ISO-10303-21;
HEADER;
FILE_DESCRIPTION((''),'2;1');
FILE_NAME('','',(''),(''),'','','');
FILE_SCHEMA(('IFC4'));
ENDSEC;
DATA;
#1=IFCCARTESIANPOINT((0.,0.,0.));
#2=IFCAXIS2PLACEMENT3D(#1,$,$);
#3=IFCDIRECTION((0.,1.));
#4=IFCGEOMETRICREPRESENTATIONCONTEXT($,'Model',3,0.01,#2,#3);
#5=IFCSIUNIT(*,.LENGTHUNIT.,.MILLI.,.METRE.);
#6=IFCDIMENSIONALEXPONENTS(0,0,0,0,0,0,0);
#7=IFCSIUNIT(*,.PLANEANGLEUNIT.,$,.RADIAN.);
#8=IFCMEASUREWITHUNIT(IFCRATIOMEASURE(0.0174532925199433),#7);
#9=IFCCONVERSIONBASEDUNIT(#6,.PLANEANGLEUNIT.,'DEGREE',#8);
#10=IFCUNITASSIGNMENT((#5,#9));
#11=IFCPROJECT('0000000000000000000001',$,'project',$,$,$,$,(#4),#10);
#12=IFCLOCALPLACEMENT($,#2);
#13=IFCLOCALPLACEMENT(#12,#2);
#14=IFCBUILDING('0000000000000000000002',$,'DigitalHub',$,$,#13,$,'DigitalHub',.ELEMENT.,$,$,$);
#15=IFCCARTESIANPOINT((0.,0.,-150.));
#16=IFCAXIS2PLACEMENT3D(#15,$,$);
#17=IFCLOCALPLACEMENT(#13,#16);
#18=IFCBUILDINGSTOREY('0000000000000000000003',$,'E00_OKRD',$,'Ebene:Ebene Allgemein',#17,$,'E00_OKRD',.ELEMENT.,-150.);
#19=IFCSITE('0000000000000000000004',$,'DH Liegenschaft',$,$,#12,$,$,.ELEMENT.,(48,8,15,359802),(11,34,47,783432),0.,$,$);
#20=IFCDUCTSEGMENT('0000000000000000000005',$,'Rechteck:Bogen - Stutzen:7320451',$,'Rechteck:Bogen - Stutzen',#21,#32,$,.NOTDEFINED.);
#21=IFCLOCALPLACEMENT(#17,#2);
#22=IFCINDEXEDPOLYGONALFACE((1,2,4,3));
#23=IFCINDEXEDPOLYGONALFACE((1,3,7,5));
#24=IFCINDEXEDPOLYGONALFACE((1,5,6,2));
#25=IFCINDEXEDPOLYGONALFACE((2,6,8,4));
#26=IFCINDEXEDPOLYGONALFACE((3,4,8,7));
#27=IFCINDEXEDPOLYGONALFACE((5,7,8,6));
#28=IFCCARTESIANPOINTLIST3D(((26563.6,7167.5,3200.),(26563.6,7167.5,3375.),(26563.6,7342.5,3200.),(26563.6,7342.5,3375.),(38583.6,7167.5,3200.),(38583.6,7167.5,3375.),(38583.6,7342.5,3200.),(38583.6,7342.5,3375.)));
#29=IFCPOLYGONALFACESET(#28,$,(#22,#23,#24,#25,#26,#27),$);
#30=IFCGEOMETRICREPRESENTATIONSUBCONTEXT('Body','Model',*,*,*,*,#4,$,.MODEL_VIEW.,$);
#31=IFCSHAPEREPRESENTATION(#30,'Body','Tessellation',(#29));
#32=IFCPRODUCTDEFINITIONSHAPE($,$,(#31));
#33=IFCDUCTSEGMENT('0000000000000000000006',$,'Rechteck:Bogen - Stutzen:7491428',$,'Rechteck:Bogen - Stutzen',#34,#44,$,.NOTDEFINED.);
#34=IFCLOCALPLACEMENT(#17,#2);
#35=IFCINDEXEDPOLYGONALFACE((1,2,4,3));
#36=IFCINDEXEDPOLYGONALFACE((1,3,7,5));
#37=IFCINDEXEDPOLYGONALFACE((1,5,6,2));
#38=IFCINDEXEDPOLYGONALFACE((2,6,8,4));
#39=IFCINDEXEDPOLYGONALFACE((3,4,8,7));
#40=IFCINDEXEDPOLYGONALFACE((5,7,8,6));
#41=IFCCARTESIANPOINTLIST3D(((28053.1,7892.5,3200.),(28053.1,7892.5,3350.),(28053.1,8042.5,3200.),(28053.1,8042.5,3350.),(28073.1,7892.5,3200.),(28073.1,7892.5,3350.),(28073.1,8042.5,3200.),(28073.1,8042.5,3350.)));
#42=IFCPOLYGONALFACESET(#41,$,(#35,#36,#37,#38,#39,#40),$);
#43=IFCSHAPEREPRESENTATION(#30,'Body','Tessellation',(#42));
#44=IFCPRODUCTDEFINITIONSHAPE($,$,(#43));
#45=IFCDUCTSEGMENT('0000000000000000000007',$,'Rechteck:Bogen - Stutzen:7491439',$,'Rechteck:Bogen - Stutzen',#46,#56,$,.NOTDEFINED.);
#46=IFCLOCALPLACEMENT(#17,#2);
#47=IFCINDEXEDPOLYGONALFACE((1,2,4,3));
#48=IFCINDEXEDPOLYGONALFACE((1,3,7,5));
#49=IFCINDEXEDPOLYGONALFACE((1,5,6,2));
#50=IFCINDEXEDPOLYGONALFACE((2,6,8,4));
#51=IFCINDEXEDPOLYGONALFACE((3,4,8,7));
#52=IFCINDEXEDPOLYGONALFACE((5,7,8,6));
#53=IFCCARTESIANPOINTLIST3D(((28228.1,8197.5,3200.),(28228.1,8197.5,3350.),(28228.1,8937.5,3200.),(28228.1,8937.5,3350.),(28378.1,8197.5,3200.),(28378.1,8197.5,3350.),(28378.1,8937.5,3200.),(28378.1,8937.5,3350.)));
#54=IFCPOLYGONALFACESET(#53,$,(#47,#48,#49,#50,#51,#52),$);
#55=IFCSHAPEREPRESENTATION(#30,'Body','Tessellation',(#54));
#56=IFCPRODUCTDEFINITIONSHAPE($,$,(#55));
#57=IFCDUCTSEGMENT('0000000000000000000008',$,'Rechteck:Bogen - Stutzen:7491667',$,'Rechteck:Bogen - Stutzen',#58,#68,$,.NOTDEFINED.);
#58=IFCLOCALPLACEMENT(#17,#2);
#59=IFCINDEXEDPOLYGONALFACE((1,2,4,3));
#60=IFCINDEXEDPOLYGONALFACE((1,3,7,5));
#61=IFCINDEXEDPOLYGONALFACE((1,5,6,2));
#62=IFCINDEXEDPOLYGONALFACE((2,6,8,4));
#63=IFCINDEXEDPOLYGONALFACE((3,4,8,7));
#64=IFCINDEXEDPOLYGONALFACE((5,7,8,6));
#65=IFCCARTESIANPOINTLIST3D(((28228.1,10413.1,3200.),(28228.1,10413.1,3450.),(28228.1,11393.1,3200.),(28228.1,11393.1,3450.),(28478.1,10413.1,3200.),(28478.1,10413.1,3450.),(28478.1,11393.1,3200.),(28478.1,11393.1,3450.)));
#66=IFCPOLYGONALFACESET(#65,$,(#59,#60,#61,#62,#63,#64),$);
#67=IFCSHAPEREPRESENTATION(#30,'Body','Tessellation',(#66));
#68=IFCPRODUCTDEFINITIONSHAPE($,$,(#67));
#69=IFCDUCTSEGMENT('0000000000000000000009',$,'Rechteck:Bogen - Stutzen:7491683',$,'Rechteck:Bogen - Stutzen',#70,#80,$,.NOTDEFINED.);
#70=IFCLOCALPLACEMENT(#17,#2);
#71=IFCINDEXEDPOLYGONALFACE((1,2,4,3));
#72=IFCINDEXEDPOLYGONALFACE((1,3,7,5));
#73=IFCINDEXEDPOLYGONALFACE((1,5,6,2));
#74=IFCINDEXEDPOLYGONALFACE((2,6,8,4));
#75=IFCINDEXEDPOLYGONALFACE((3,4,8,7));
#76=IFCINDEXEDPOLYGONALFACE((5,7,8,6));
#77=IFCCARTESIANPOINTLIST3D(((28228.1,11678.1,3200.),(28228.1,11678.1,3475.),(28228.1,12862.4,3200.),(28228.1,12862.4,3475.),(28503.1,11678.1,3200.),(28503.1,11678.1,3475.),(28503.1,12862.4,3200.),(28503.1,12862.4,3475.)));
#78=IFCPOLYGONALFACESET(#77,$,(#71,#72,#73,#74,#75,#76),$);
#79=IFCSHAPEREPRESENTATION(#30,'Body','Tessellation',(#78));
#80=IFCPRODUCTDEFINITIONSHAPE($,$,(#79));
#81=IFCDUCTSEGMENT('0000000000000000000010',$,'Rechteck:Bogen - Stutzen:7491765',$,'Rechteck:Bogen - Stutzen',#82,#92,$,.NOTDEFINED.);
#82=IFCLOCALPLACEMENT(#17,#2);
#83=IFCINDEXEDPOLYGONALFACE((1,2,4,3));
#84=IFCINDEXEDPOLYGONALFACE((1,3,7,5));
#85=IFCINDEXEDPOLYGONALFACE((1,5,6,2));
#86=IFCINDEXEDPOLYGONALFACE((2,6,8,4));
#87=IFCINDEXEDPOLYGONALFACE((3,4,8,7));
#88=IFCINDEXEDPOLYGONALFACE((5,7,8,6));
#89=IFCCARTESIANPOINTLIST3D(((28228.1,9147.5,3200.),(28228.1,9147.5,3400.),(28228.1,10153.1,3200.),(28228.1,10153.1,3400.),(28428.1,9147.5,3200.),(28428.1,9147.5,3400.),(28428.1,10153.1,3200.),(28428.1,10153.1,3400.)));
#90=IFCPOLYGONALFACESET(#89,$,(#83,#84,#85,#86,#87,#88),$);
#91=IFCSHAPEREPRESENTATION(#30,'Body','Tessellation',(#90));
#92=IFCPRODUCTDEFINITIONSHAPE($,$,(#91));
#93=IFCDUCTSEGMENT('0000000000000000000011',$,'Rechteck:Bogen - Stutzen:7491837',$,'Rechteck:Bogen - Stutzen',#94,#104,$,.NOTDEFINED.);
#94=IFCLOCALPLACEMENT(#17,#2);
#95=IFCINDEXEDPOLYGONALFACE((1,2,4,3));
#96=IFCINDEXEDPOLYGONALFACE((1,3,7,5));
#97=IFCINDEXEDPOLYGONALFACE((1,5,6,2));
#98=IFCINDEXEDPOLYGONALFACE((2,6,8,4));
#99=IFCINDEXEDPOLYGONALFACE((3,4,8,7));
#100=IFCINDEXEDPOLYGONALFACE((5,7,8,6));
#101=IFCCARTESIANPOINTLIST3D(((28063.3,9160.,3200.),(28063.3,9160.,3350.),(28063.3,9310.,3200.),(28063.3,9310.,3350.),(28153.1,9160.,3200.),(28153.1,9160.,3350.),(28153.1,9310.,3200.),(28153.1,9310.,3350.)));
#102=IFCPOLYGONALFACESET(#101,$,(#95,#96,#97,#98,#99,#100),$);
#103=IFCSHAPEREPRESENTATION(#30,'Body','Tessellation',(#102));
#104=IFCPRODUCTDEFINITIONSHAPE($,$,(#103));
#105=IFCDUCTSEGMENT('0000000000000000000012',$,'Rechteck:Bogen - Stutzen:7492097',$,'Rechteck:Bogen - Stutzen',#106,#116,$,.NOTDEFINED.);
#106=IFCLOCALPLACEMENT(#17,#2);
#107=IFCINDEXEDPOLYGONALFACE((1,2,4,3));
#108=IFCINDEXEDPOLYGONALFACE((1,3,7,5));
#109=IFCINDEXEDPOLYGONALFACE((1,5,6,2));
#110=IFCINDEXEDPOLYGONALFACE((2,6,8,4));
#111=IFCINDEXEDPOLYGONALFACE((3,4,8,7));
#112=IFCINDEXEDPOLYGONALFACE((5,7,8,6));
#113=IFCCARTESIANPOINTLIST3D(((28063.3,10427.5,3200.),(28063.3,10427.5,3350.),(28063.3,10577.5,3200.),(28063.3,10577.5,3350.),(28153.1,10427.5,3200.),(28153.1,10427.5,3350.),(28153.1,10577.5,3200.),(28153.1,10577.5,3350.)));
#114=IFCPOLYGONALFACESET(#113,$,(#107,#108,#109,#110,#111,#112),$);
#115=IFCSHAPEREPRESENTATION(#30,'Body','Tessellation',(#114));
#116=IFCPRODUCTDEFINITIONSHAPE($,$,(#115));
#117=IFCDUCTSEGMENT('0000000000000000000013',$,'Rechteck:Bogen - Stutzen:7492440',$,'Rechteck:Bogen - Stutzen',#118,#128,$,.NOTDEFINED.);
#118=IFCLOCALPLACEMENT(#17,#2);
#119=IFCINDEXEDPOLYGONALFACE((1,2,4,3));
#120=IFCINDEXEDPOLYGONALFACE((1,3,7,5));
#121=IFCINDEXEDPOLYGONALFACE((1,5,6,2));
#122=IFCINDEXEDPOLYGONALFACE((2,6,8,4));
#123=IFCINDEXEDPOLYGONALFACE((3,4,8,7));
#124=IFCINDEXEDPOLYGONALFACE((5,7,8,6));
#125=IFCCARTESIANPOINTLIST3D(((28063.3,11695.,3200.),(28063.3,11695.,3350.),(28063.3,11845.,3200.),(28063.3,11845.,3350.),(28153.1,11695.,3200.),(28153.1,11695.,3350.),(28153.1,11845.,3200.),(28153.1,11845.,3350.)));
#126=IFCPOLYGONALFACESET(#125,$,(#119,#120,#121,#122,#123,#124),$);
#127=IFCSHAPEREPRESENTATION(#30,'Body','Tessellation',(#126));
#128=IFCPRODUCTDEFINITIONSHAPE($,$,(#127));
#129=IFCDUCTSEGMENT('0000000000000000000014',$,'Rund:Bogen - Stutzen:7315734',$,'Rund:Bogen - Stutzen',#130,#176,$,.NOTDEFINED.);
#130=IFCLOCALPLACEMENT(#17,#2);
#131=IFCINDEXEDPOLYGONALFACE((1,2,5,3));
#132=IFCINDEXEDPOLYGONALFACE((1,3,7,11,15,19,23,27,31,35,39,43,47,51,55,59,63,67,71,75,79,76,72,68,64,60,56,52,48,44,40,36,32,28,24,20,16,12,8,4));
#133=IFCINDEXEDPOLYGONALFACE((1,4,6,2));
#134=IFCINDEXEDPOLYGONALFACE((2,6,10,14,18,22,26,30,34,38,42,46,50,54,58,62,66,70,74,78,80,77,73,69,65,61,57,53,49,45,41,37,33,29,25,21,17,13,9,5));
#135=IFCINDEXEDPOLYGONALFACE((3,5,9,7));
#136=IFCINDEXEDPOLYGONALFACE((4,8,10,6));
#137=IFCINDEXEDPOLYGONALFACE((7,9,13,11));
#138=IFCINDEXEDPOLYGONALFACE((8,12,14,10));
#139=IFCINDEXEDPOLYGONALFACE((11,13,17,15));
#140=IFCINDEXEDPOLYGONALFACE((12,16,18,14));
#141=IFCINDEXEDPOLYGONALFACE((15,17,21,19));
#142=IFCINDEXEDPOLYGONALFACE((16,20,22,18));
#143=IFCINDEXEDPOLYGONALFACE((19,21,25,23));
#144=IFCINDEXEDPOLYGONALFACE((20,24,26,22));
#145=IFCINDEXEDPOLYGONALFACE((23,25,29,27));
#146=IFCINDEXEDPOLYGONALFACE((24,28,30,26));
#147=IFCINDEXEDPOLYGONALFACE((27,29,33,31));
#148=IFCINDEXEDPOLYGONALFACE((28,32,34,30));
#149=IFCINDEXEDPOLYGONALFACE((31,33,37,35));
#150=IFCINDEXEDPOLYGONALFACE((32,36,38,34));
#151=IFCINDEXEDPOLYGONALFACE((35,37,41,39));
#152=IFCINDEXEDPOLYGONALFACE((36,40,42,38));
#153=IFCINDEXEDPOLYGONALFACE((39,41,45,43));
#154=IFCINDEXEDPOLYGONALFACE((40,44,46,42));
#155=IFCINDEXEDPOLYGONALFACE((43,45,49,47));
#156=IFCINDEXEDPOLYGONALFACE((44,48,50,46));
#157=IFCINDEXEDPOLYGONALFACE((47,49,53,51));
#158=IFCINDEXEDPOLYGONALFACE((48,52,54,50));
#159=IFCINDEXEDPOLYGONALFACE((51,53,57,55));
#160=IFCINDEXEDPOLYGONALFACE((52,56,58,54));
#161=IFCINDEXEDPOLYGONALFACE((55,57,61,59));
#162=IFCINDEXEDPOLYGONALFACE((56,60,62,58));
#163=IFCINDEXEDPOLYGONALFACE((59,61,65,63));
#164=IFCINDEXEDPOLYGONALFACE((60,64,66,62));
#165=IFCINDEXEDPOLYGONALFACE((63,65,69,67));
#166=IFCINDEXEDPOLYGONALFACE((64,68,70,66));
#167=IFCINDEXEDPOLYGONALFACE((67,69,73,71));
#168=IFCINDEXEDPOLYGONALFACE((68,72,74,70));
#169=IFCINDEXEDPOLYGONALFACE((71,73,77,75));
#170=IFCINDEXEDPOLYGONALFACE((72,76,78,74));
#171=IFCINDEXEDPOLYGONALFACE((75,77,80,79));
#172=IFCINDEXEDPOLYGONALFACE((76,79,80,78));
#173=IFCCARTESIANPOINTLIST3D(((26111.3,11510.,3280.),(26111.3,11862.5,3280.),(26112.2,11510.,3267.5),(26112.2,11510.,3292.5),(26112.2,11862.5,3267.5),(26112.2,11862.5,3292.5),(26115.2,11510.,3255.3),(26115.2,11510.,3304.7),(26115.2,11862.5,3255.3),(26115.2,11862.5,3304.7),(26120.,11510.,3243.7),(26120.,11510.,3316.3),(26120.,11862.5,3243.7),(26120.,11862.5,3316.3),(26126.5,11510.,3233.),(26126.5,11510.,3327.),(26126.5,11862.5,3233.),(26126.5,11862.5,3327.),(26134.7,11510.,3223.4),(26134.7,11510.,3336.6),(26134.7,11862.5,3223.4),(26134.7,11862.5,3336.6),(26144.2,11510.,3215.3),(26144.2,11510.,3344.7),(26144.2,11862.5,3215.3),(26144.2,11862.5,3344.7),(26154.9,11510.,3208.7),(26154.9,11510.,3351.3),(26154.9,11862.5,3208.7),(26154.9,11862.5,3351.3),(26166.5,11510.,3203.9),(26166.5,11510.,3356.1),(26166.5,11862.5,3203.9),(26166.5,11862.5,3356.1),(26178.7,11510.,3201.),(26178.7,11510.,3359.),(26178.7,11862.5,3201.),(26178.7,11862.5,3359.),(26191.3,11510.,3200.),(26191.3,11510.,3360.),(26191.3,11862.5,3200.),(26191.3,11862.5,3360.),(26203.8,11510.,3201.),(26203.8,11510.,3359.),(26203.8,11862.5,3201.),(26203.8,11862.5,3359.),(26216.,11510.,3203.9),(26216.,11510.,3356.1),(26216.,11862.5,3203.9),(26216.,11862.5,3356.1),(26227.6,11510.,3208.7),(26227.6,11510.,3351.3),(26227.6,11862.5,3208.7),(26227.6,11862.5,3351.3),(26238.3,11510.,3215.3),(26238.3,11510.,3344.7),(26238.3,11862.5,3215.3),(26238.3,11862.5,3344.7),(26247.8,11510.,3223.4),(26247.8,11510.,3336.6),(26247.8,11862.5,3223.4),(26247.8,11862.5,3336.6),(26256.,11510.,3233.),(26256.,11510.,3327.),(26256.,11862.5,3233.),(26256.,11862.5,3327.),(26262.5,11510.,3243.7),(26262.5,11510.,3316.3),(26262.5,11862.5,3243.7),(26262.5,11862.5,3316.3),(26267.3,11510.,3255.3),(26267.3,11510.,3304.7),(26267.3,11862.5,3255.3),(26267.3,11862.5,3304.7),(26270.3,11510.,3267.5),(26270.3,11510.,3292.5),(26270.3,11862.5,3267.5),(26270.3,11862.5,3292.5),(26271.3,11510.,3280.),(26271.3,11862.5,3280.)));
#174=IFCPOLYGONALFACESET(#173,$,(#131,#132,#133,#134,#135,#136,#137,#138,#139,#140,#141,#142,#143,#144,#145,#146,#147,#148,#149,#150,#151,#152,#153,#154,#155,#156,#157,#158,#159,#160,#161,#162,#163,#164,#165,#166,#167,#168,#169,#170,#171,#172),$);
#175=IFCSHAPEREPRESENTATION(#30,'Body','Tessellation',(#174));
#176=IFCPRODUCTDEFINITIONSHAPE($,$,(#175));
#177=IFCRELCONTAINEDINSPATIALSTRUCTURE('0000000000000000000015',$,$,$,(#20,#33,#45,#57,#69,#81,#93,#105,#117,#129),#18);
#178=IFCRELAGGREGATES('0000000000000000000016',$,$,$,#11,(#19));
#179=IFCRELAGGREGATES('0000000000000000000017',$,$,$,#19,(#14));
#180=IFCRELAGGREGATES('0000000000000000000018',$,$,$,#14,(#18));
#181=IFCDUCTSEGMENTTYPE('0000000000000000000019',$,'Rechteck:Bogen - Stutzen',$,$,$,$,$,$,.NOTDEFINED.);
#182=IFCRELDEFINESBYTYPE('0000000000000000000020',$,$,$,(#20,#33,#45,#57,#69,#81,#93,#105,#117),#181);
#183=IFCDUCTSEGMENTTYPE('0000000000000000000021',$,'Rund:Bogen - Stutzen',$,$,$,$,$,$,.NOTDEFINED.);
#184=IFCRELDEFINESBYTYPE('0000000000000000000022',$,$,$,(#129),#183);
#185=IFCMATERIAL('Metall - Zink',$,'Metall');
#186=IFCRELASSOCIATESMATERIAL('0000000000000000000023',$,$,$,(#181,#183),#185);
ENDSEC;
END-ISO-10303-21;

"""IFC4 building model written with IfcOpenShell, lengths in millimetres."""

from ifc_helpers import new_model, entity, si_unit, converted_unit, direction, frame, origin, place, context, subcontext, project, spatial, indexed_curve, outline, extrude, material, type_object, element, save


model = new_model("IFC4")

# Units and contexts
model_context = context("Model", 3, precision=0.01, world=origin(), true_north=direction((0.0, 1.0)))
body_context = subcontext(model_context, "Body", "Model", "MODEL_VIEW")
ifc_project = project(units=[si_unit("LENGTHUNIT", "METRE", prefix="MILLI"), converted_unit("PLANEANGLEUNIT", "DEGREE", entity("IfcRatioMeasure", 0.0174532925199433), si_unit("PLANEANGLEUNIT", "RADIAN"), dimensions=[0, 0, 0, 0, 0, 0, 0])], contexts=[model_context])

# Site, building, storey
site_placement = place(None, origin())
site = spatial("IfcSite", under=ifc_project, at=site_placement, Name="DH Liegenschaft", CompositionType="ELEMENT", RefLatitude=(48, 8, 15, 359802), RefLongitude=(11, 34, 47, 783432), RefElevation=0.0)
building_placement = place(site_placement, origin())
building = spatial("IfcBuilding", under=site, at=building_placement, Name="DigitalHub", LongName="DigitalHub", CompositionType="ELEMENT")
storey_placement = place(building_placement, frame((0.0, 0.0, -150.0)))
storey = spatial("IfcBuildingStorey", under=building, at=storey_placement, Name="E00_OKRD", ObjectType="Ebene:Ebene Allgemein", LongName="E00_OKRD", CompositionType="ELEMENT", Elevation=-150.0)

# Duct segments
ifc_material_1 = material(Name="Metall - Zink", Category="Metall")
duct_segment_type_1 = type_object("IfcDuctSegmentType", Name="Rechteck:Bogen - Stutzen", PredefinedType="NOTDEFINED", material=ifc_material_1)
duct_segment_1_placement = place(storey_placement, frame((26563.6, 7167.5, 3200.0)))
element("IfcDuctSegment", 1, at=duct_segment_1_placement, inside=storey, type_object=duct_segment_type_1, Name="Rechteck:Bogen - Stutzen:7320451", ObjectType="Rechteck:Bogen - Stutzen", PredefinedType="NOTDEFINED", context=body_context, shape_type="SweptSolid", body=[
    extrude(outline(indexed_curve([(-6010.0, -87.5), (6010.0, -87.5), (6010.0, 87.5), (-6010.0, 87.5), (-6010.0, -87.5)], self_intersect=False)), frame((6010.0, 87.5, 0.0), z_axis=(0.0, 0.0, 1.0), x_axis=(-1.0, 0.0, 0.0)), (0.0, 0.0, 1.0), 175.0),
])
duct_segment_2_placement = place(storey_placement, frame((28053.1, 7892.5, 3200.0)))
element("IfcDuctSegment", 2, at=duct_segment_2_placement, inside=storey, type_object=duct_segment_type_1, Name="Rechteck:Bogen - Stutzen:7491428", ObjectType="Rechteck:Bogen - Stutzen", PredefinedType="NOTDEFINED", context=body_context, shape_type="SweptSolid", body=[
    extrude(outline(indexed_curve([(-10.0, -75.0), (10.0, -75.0), (10.0, 75.0), (-10.0, 75.0), (-10.0, -75.0)], self_intersect=False)), frame((10.0, 75.0, 0.0)), (0.0, 0.0, 1.0), 150.0),
])
duct_segment_3_placement = place(storey_placement, frame((28228.1, 8197.5, 3200.0)))
element("IfcDuctSegment", 3, at=duct_segment_3_placement, inside=storey, type_object=duct_segment_type_1, Name="Rechteck:Bogen - Stutzen:7491439", ObjectType="Rechteck:Bogen - Stutzen", PredefinedType="NOTDEFINED", context=body_context, shape_type="SweptSolid", body=[
    extrude(outline(indexed_curve([(-370.0, -75.0), (370.0, -75.0), (370.0, 75.0), (-370.0, 75.0), (-370.0, -75.0)], self_intersect=False)), frame((75.0, 370.0, 0.0), z_axis=(0.0, 0.0, 1.0), x_axis=(0.0, 1.0, 0.0)), (0.0, 0.0, 1.0), 150.0),
])
duct_segment_4_placement = place(storey_placement, frame((28228.1, 10413.1, 3200.0)))
element("IfcDuctSegment", 4, at=duct_segment_4_placement, inside=storey, type_object=duct_segment_type_1, Name="Rechteck:Bogen - Stutzen:7491667", ObjectType="Rechteck:Bogen - Stutzen", PredefinedType="NOTDEFINED", context=body_context, shape_type="SweptSolid", body=[
    extrude(outline(indexed_curve([(-490.0, -125.0), (490.0, -125.0), (490.0, 125.0), (-490.0, 125.0), (-490.0, -125.0)], self_intersect=False)), frame((125.0, 490.0, 0.0), z_axis=(0.0, 0.0, 1.0), x_axis=(0.0, 1.0, 0.0)), (0.0, 0.0, 1.0), 250.0),
])
duct_segment_5_placement = place(storey_placement, frame((28228.1, 11678.1, 3200.0)))
element("IfcDuctSegment", 5, at=duct_segment_5_placement, inside=storey, type_object=duct_segment_type_1, Name="Rechteck:Bogen - Stutzen:7491683", ObjectType="Rechteck:Bogen - Stutzen", PredefinedType="NOTDEFINED", context=body_context, shape_type="SweptSolid", body=[
    extrude(outline(indexed_curve([(-592.2, -137.5), (592.2, -137.5), (592.2, 137.5), (-592.2, 137.5), (-592.2, -137.5)], self_intersect=False)), frame((137.5, 592.2, 0.0), z_axis=(0.0, 0.0, 1.0), x_axis=(0.0, 1.0, 0.0)), (0.0, 0.0, 1.0), 275.0),
])
duct_segment_6_placement = place(storey_placement, frame((28228.1, 9147.5, 3200.0)))
element("IfcDuctSegment", 6, at=duct_segment_6_placement, inside=storey, type_object=duct_segment_type_1, Name="Rechteck:Bogen - Stutzen:7491765", ObjectType="Rechteck:Bogen - Stutzen", PredefinedType="NOTDEFINED", context=body_context, shape_type="SweptSolid", body=[
    extrude(outline(indexed_curve([(-502.8, -100.0), (502.8, -100.0), (502.8, 100.0), (-502.8, 100.0), (-502.8, -100.0)], self_intersect=False)), frame((100.0, 502.8, 0.0), z_axis=(0.0, 0.0, 1.0), x_axis=(0.0, 1.0, 0.0)), (0.0, 0.0, 1.0), 200.0),
])
duct_segment_7_placement = place(storey_placement, frame((28063.3, 9160.0, 3200.0)))
element("IfcDuctSegment", 7, at=duct_segment_7_placement, inside=storey, type_object=duct_segment_type_1, Name="Rechteck:Bogen - Stutzen:7491837", ObjectType="Rechteck:Bogen - Stutzen", PredefinedType="NOTDEFINED", context=body_context, shape_type="SweptSolid", body=[
    extrude(outline(indexed_curve([(-44.9, -75.0), (44.9, -75.0), (44.9, 75.0), (-44.9, 75.0), (-44.9, -75.0)], self_intersect=False)), frame((44.9, 75.0, 0.0), z_axis=(0.0, 0.0, 1.0), x_axis=(-1.0, 0.0, 0.0)), (0.0, 0.0, 1.0), 150.0),
])
duct_segment_8_placement = place(storey_placement, frame((28063.3, 10427.5, 3200.0)))
element("IfcDuctSegment", 8, at=duct_segment_8_placement, inside=storey, type_object=duct_segment_type_1, Name="Rechteck:Bogen - Stutzen:7492097", ObjectType="Rechteck:Bogen - Stutzen", PredefinedType="NOTDEFINED", context=body_context, shape_type="SweptSolid", body=[
    extrude(outline(indexed_curve([(-44.9, -75.0), (44.9, -75.0), (44.9, 75.0), (-44.9, 75.0), (-44.9, -75.0)], self_intersect=False)), frame((44.9, 75.0, 0.0), z_axis=(0.0, 0.0, 1.0), x_axis=(-1.0, 0.0, 0.0)), (0.0, 0.0, 1.0), 150.0),
])
duct_segment_9_placement = place(storey_placement, frame((28063.3, 11695.0, 3200.0)))
element("IfcDuctSegment", 9, at=duct_segment_9_placement, inside=storey, type_object=duct_segment_type_1, Name="Rechteck:Bogen - Stutzen:7492440", ObjectType="Rechteck:Bogen - Stutzen", PredefinedType="NOTDEFINED", context=body_context, shape_type="SweptSolid", body=[
    extrude(outline(indexed_curve([(-44.9, -75.0), (44.9, -75.0), (44.9, 75.0), (-44.9, 75.0), (-44.9, -75.0)], self_intersect=False)), frame((44.9, 75.0, 0.0), z_axis=(0.0, 0.0, 1.0), x_axis=(-1.0, 0.0, 0.0)), (0.0, 0.0, 1.0), 150.0),
])
duct_segment_type_2 = type_object("IfcDuctSegmentType", Name="Rund:Bogen - Stutzen", PredefinedType="NOTDEFINED", material=ifc_material_1)
duct_segment_10_placement = place(storey_placement, frame((26109.7, 11510.0, 3198.4)))
element("IfcDuctSegment", 10, at=duct_segment_10_placement, inside=storey, type_object=duct_segment_type_2, Name="Rund:Bogen - Stutzen:7315734", ObjectType="Rund:Bogen - Stutzen", PredefinedType="NOTDEFINED", context=body_context, shape_type="SweptSolid", body=[
    extrude(outline(indexed_curve([(80.0, 0.0), (79.0, 12.5), (76.1, 24.7), (71.3, 36.3), (64.7, 47.0), (56.6, 56.6), (47.0, 64.7), (36.3, 71.3), (24.7, 76.1), (12.5, 79.0), (0.0, 80.0), (-12.5, 79.0), (-24.7, 76.1), (-36.3, 71.3), (-47.0, 64.7), (-56.6, 56.6), (-64.7, 47.0), (-71.3, 36.3), (-76.1, 24.7), (-79.0, 12.5), (-80.0, 0.0), (-79.0, -12.5), (-76.1, -24.7), (-71.3, -36.3), (-64.7, -47.0), (-56.6, -56.6), (-47.0, -64.7), (-36.3, -71.3), (-24.7, -76.1), (-12.5, -79.0), (0.0, -80.0), (12.5, -79.0), (24.7, -76.1), (36.3, -71.3), (47.0, -64.7), (56.6, -56.6), (64.7, -47.0), (71.3, -36.3), (76.1, -24.7), (79.0, -12.5), (80.0, 0.0)], self_intersect=False)), frame((81.6, 0.0, 81.6), z_axis=(0.0, 1.0, 0.0), x_axis=(-1.0, 0.0, 0.0)), (0.0, 0.0, 1.0), 352.5),
])

save(model, "model.ifc")
